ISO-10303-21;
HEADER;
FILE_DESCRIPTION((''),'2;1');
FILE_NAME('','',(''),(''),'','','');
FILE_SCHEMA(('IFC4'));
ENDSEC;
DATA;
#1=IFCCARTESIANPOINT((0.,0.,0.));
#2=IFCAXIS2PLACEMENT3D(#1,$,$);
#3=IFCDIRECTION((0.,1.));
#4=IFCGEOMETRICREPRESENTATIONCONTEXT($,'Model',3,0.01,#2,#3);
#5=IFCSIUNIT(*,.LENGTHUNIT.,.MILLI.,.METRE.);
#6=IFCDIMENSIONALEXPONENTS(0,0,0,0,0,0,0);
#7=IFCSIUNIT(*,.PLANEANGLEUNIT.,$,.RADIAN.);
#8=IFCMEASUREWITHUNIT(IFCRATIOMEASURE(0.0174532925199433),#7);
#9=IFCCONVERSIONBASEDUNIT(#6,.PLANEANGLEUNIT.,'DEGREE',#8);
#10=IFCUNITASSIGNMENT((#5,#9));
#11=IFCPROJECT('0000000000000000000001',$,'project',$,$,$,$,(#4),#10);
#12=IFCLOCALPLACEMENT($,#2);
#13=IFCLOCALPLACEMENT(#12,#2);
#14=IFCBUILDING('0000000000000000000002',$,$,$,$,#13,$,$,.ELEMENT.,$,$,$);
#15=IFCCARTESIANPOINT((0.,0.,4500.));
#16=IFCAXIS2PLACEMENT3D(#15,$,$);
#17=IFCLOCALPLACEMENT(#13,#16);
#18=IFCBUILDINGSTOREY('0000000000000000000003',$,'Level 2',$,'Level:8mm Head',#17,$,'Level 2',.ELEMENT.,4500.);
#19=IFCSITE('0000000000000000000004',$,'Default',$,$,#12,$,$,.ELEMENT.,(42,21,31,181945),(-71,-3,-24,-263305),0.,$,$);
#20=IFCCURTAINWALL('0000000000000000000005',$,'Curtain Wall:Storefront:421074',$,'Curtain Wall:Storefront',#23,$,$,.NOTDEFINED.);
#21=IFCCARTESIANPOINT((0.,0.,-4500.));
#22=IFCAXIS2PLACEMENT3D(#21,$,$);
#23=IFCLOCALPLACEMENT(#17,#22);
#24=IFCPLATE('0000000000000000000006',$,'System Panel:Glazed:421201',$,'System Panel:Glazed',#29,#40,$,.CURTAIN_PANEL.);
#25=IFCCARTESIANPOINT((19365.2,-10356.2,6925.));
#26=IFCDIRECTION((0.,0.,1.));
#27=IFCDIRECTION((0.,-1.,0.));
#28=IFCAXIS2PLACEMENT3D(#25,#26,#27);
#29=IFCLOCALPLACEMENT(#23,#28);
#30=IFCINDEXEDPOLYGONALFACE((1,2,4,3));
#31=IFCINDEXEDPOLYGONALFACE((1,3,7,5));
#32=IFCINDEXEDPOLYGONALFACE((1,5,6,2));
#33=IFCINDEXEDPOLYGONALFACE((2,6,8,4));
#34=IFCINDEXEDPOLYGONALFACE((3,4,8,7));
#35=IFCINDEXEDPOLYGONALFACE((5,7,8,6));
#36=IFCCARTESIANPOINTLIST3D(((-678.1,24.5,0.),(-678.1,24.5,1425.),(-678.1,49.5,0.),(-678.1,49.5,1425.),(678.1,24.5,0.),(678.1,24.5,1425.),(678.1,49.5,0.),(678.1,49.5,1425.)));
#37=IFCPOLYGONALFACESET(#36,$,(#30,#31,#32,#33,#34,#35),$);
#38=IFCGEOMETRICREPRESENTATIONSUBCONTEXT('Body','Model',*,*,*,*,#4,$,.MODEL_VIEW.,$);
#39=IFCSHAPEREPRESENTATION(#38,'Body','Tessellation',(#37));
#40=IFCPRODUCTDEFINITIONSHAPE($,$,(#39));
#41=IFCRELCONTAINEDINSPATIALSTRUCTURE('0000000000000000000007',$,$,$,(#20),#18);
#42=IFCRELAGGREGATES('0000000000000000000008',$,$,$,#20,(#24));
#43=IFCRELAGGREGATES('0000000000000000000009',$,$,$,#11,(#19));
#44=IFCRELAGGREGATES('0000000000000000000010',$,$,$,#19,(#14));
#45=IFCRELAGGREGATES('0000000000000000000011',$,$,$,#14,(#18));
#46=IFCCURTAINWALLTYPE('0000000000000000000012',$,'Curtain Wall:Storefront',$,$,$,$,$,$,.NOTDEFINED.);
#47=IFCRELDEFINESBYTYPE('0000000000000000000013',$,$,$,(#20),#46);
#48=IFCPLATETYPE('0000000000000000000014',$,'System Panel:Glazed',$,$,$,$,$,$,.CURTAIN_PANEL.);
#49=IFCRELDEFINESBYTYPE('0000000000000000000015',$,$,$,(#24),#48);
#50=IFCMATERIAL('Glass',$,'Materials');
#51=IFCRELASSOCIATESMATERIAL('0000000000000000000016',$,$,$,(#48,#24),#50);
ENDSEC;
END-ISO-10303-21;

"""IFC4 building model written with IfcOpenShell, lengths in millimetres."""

from ifc_helpers import new_model, entity, si_unit, converted_unit, direction, frame, origin, place, context, subcontext, project, spatial, indexed_curve, outline, extrude, shape, source, transform, mapped, material, type_object, type_shapes, element, aggregate, save


model = new_model("IFC4")

# Units and contexts
model_context = context("Model", 3, precision=0.01, world=origin(), true_north=direction((0.0, 1.0)))
body_context = subcontext(model_context, "Body", "Model", "MODEL_VIEW")
footprint_context = subcontext(model_context, "FootPrint", "Model", "MODEL_VIEW")
ifc_project = project(units=[si_unit("LENGTHUNIT", "METRE", prefix="MILLI"), converted_unit("PLANEANGLEUNIT", "DEGREE", entity("IfcRatioMeasure", 0.0174532925199433), si_unit("PLANEANGLEUNIT", "RADIAN"), dimensions=[0, 0, 0, 0, 0, 0, 0])], contexts=[model_context])

# Site, building, storey
site_placement = place(None, origin())
site = spatial("IfcSite", under=ifc_project, at=site_placement, Name="Default", CompositionType="ELEMENT", RefLatitude=(42, 21, 31, 181945), RefLongitude=(-71, -3, -24, -263305), RefElevation=0.0)
building_placement = place(site_placement, origin())
building = spatial("IfcBuilding", under=site, at=building_placement, CompositionType="ELEMENT")
storey_placement = place(building_placement, frame((0.0, 0.0, 4500.0)))
storey = spatial("IfcBuildingStorey", under=building, at=storey_placement, Name="Level 2", ObjectType="Level:8mm Head", LongName="Level 2", CompositionType="ELEMENT", Elevation=4500.0)

# Curtain wall
curtain_wall_type_1 = type_object("IfcCurtainWallType", Name="Curtain Wall:Storefront", PredefinedType="NOTDEFINED")
curtain_wall_1_placement = place(storey_placement, frame((0.0, 0.0, -4500.0)))
curtain_wall_1 = element("IfcCurtainWall", 1, at=curtain_wall_1_placement, inside=storey, type_object=curtain_wall_type_1, Name="Curtain Wall:Storefront:421074", ObjectType="Curtain Wall:Storefront", PredefinedType="NOTDEFINED")

# Plate
ifc_material_1 = material(Name="Glass", Category="Materials")
plate_type_1 = type_object("IfcPlateType", Name="System Panel:Glazed", PredefinedType="CURTAIN_PANEL", material=ifc_material_1)
shared_shape_1 = source(origin(), body_context, "Body", "SweptSolid", [
    extrude(outline(indexed_curve([(-12.5, -678.1), (12.5, -678.1), (12.5, 678.1), (-12.5, 678.1), (-12.5, -678.1)], self_intersect=False)), frame((0.0, 37.0, 0.0), z_axis=(0.0, 0.0, 1.0), x_axis=(0.0, 1.0, 0.0)), (0.0, 0.0, 1.0), 1425.0),
])
shared_shape_2 = source(origin(), footprint_context, "FootPrint", "Curve2D", [
    entity("IfcIndexedPolyCurve", entity("IfcCartesianPointList2D", [[678.1, 24.5], [678.1, 49.5], [-678.1, 49.5], [-678.1, 24.5], [678.1, 24.5]]), None, False),
])
type_shapes(plate_type_1, [shared_shape_1, shared_shape_2])
plate_1_placement = place(curtain_wall_1_placement, frame((19365.2, -10356.2, 6925.0), z_axis=(0.0, 0.0, 1.0), x_axis=(0.0, -1.0, 0.0)))
plate_1 = element("IfcPlate", 2, at=plate_1_placement, type_object=plate_type_1, material=ifc_material_1, Name="System Panel:Glazed:421201", ObjectType="System Panel:Glazed", PredefinedType="CURTAIN_PANEL", shapes=[
    shape(body_context, "Body", "MappedRepresentation", [mapped(shared_shape_1, transform((0.0, 0.0, 0.0), scale=1.0))]),
    shape(body_context, "Body", "MappedRepresentation", [mapped(shared_shape_2, transform((0.0, 0.0, 0.0), scale=1.0))]),
])
aggregate(curtain_wall_1, [plate_1])

save(model, "model.ifc")
